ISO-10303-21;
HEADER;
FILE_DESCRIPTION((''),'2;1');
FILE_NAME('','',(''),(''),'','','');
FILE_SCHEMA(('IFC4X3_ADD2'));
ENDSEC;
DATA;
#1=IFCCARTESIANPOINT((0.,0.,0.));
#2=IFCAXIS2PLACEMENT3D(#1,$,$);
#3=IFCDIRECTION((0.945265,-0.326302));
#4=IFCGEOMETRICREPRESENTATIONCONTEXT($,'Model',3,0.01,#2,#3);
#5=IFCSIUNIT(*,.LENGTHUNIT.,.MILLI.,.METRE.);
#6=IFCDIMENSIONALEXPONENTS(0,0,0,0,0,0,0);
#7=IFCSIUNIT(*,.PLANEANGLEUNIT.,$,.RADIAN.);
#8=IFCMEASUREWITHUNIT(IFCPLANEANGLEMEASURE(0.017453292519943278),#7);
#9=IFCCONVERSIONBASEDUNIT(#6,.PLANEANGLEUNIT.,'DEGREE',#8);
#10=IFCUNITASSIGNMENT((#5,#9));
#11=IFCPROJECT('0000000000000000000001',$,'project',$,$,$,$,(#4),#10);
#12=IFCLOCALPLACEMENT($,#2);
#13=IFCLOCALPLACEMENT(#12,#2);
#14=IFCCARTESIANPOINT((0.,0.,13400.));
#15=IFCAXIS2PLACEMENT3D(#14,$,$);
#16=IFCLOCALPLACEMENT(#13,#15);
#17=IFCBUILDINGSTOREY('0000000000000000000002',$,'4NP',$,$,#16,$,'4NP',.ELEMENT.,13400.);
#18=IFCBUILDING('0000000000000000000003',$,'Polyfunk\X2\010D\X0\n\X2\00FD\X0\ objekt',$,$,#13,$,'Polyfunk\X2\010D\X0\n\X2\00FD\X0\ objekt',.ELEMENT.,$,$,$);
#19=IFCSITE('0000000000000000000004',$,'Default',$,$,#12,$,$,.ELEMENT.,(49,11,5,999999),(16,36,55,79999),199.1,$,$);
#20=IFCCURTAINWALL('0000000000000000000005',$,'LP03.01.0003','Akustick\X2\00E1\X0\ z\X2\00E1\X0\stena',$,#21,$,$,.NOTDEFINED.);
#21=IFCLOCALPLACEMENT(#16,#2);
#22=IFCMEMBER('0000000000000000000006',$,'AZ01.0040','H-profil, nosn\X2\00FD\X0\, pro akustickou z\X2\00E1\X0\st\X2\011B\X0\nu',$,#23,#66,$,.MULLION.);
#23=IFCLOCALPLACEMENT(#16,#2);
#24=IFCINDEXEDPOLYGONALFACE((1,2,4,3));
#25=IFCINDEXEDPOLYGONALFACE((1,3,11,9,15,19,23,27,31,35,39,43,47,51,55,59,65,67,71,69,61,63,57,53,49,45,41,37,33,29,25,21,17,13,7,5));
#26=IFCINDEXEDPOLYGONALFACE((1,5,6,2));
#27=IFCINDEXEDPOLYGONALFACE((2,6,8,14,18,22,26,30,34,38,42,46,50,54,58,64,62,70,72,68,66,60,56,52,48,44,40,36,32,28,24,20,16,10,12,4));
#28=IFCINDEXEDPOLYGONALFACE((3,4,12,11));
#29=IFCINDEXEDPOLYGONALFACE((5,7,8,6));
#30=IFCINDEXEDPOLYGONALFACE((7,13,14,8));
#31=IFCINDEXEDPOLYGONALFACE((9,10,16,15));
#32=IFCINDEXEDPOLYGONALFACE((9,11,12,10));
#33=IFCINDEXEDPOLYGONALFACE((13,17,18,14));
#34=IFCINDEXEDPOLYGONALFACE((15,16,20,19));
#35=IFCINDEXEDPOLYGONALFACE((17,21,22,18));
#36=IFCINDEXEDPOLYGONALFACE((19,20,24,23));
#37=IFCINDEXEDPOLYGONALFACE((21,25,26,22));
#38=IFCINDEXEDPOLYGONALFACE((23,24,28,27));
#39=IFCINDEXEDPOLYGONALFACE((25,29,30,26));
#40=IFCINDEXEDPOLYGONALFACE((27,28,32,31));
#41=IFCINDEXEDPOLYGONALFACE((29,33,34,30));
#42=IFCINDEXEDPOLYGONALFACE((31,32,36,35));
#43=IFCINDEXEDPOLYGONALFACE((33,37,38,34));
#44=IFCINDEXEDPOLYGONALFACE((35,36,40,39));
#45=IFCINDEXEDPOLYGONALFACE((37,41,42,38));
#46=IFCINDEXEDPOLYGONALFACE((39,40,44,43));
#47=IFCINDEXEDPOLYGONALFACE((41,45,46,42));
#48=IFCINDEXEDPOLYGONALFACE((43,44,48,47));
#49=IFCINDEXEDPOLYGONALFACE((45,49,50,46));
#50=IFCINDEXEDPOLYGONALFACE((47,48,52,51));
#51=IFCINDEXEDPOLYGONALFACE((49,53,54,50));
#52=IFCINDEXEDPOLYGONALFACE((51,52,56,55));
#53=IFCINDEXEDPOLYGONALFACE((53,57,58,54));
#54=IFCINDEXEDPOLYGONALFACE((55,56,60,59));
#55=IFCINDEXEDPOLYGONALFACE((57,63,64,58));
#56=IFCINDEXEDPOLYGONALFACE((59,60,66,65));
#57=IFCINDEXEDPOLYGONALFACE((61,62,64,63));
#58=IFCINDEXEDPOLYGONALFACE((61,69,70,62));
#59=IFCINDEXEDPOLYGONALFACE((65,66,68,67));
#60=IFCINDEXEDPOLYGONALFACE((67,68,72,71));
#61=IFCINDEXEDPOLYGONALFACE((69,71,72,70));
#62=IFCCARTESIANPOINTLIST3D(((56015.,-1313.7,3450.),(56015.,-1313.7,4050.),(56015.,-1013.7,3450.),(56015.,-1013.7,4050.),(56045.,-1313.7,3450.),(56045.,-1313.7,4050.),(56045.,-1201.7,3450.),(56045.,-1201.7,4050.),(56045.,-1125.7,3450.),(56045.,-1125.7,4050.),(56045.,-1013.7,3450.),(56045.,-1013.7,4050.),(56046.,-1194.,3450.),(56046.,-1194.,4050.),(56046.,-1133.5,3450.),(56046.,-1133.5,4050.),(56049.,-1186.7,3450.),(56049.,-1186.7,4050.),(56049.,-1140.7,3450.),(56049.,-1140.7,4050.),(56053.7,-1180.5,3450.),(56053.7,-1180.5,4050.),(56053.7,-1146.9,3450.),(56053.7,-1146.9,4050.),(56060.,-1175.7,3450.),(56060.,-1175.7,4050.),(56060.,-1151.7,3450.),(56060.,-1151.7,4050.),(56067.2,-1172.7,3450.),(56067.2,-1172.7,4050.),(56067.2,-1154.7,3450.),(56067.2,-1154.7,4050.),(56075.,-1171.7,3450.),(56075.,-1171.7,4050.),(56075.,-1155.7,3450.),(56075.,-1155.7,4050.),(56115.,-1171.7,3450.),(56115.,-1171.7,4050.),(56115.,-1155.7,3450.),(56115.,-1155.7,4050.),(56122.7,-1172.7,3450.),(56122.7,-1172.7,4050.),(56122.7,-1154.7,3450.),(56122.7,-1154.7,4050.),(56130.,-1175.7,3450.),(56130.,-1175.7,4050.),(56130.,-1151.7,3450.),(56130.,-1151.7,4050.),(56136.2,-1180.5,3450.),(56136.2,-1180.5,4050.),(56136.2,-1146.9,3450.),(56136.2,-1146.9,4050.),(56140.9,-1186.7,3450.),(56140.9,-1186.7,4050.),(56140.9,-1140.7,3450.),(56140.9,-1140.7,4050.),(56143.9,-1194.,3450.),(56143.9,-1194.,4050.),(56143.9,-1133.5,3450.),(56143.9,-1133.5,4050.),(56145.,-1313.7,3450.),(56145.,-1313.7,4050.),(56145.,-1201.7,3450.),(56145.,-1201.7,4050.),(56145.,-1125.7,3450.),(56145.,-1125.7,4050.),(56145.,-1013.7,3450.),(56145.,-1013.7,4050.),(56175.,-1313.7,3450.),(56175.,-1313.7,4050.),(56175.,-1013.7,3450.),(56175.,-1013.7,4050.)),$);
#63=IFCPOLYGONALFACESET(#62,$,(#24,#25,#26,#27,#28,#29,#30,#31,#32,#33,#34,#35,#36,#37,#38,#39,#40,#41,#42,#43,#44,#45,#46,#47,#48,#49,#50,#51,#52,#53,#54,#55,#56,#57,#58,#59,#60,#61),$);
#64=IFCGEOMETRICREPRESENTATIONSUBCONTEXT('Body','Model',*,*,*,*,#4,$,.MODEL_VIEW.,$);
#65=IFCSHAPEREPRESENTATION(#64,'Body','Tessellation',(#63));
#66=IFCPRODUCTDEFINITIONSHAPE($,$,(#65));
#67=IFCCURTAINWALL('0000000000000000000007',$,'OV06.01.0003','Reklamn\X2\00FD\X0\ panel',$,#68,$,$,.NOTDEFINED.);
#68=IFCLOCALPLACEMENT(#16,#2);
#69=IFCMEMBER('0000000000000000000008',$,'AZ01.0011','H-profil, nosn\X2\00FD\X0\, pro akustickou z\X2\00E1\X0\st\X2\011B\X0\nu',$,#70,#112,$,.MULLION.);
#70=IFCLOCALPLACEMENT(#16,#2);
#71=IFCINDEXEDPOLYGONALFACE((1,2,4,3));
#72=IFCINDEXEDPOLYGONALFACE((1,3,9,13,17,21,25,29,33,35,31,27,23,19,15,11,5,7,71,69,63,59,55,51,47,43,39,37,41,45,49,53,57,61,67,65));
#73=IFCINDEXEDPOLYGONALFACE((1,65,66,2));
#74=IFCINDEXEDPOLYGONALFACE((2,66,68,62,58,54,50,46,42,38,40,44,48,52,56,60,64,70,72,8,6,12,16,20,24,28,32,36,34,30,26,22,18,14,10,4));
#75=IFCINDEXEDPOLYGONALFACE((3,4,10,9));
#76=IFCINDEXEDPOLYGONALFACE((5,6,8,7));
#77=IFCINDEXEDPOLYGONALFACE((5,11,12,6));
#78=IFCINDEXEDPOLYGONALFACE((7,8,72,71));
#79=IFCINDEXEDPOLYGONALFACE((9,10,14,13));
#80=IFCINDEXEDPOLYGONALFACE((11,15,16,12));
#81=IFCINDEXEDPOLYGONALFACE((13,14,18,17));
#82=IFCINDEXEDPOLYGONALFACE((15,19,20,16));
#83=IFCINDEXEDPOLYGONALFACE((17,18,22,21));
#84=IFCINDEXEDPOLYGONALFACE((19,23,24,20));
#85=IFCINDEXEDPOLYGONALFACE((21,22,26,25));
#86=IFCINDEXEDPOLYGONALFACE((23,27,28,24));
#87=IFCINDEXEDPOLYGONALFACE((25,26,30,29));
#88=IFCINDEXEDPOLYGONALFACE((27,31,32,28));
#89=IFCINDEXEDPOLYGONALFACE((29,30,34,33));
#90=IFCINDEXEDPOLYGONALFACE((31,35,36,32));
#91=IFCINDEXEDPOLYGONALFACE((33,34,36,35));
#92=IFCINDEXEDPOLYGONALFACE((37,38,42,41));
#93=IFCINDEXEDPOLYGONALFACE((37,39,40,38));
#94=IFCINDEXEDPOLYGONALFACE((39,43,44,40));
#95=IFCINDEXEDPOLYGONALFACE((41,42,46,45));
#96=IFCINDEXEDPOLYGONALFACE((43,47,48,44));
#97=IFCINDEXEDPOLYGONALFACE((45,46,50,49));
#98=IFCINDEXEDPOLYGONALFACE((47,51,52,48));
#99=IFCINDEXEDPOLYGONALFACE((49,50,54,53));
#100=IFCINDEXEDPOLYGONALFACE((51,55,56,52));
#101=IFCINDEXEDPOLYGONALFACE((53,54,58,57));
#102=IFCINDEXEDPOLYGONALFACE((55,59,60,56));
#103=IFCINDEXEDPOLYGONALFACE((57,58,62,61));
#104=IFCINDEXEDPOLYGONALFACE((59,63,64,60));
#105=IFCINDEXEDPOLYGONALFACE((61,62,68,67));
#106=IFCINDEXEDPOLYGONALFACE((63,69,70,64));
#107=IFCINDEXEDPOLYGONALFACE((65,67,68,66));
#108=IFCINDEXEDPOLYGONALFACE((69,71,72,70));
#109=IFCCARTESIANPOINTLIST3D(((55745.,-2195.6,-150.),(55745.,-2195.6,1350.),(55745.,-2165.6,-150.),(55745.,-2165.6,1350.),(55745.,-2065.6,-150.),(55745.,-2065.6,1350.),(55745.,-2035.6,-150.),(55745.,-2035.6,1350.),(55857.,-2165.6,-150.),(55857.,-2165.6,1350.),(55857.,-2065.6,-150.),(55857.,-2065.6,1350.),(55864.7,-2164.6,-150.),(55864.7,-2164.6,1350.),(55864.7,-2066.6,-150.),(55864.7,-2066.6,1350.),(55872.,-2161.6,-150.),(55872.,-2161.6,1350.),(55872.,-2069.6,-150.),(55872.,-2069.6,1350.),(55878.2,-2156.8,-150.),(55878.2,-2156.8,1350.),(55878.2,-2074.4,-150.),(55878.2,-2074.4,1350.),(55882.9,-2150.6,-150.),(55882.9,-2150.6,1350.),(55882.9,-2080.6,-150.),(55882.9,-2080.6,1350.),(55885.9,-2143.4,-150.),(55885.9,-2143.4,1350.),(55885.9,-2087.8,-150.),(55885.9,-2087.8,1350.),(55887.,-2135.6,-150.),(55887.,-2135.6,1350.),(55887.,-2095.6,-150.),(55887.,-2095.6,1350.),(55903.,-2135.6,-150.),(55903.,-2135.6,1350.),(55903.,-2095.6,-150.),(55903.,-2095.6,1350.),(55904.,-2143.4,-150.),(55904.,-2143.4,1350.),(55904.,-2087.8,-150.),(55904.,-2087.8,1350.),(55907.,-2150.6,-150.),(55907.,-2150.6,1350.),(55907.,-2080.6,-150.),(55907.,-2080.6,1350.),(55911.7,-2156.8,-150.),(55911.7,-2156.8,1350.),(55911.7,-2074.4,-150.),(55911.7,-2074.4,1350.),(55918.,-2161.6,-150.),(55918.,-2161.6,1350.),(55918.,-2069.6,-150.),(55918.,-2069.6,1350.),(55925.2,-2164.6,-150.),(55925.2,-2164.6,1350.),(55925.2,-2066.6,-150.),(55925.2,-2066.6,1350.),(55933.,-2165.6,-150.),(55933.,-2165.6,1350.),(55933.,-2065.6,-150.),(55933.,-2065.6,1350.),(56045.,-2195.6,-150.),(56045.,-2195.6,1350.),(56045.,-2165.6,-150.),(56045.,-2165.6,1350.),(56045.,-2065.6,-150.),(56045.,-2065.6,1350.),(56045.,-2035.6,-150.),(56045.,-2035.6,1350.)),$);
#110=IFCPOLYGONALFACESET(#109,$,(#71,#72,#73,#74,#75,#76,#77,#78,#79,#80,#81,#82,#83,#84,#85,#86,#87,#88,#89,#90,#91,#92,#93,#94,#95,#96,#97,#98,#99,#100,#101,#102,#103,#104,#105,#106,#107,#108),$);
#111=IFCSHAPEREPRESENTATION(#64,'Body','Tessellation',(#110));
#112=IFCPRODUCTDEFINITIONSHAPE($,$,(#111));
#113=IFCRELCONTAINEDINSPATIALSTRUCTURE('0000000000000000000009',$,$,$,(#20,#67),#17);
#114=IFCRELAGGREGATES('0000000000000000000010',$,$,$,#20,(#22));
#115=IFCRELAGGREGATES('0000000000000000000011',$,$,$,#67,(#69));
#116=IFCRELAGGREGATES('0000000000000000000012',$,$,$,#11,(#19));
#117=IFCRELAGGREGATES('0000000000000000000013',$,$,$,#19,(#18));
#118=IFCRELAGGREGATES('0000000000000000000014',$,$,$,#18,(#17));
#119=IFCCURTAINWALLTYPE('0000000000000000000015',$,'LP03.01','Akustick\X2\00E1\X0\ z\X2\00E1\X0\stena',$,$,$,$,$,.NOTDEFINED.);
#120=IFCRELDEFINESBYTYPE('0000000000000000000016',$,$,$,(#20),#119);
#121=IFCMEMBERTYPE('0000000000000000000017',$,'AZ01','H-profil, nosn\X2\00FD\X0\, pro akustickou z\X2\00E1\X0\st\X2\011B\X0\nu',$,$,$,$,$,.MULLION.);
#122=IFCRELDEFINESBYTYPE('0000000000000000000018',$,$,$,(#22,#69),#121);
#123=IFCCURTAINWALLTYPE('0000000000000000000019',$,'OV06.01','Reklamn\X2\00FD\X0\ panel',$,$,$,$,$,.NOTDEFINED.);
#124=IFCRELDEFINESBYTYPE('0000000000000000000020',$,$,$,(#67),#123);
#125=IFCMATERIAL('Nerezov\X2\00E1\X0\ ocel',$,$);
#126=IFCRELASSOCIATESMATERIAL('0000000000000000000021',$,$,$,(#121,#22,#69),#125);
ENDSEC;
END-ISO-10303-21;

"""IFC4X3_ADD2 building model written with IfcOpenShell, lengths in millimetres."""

from ifc_helpers import new_model, entity, si_unit, converted_unit, direction, frame, frame_2d, origin, place, context, subcontext, project, spatial, polyline, circle_curve, parameter, trimmed, segment, composite_curve, outline, extrude, source, transform, mapped, material, material_profile, profile_set, profile_usage, type_object, element, aggregate, save


model = new_model("IFC4X3_ADD2")

# Units and contexts
model_context = context("Model", 3, precision=0.01, world=origin(), true_north=direction((0.945265, -0.326302)))
body_context = subcontext(model_context, "Body", "Model", "MODEL_VIEW")
ifc_project = project(units=[si_unit("LENGTHUNIT", "METRE", prefix="MILLI"), converted_unit("PLANEANGLEUNIT", "DEGREE", entity("IfcPlaneAngleMeasure", 0.017453292519943278), si_unit("PLANEANGLEUNIT", "RADIAN"), dimensions=[0, 0, 0, 0, 0, 0, 0])], contexts=[model_context])

# Site, building, storey
site_placement = place(None, origin())
site = spatial("IfcSite", under=ifc_project, at=site_placement, Name="Default", CompositionType="ELEMENT", RefLatitude=(49, 11, 5, 999999), RefLongitude=(16, 36, 55, 79999), RefElevation=199.1)
building_placement = place(site_placement, origin())
building = spatial("IfcBuilding", under=site, at=building_placement, Name="Polyfunkčný objekt", LongName="Polyfunkčný objekt", CompositionType="ELEMENT")
storey_placement = place(building_placement, frame((0.0, 0.0, 13400.0)))
storey = spatial("IfcBuildingStorey", under=building, at=storey_placement, Name="4NP", LongName="4NP", CompositionType="ELEMENT", Elevation=13400.0)

# Shared definitions
curtain_wall_type_1 = type_object("IfcCurtainWallType", Name="LP03.01", Description="Akustická zástena", PredefinedType="NOTDEFINED")
ifc_material_1 = material(Name="Nerezová ocel")
ifc_material_profile = material_profile(ifc_material_1, outline(composite_curve([segment(polyline([(50.0, -150.0), (80.0, -150.0)]), True, "CONTINUOUS"), segment(polyline([(80.0, -150.0), (80.0, 150.0)]), True, "CONTINUOUS"), segment(polyline([(80.0, 150.0), (50.0, 150.0)]), True, "CONTINUOUS"), segment(polyline([(50.0, 150.0), (50.0, 38.0)]), True, "CONTINUOUS"), segment(trimmed(circle_curve(frame_2d((20.0, 38.0), x_axis=(0.0, 1.0)), 30.0), [parameter(180.0)], [parameter(270.0)], True, "PARAMETER"), False, "CONTINUOUS"), segment(polyline([(20.0, 8.0), (-20.0, 8.0)]), True, "CONTINUOUS"), segment(trimmed(circle_curve(frame_2d((-20.0, 38.0), x_axis=(0.0, 1.0)), 30.0), [parameter(90.0)], [parameter(180.0)], True, "PARAMETER"), False, "CONTINUOUS"), segment(polyline([(-50.0, 38.0), (-50.0, 150.0)]), True, "CONTINUOUS"), segment(polyline([(-50.0, 150.0), (-80.0, 150.0)]), True, "CONTINUOUS"), segment(polyline([(-80.0, 150.0), (-80.0, -150.0)]), True, "CONTINUOUS"), segment(polyline([(-80.0, -150.0), (-50.0, -150.0)]), True, "CONTINUOUS"), segment(polyline([(-50.0, -150.0), (-50.0, -38.0)]), True, "CONTINUOUS"), segment(trimmed(circle_curve(frame_2d((-20.0, -38.0), x_axis=(0.0, 1.0)), 30.0), [parameter(0.0)], [parameter(90.0)], True, "PARAMETER"), False, "CONTINUOUS"), segment(polyline([(-20.0, -8.0), (20.0, -8.0)]), True, "CONTINUOUS"), segment(trimmed(circle_curve(frame_2d((20.0, -38.0), x_axis=(0.0, 1.0)), 30.0), [parameter(270.0)], [parameter(0.0)], True, "PARAMETER"), False, "CONTINUOUS"), segment(polyline([(50.0, -38.0), (50.0, -150.0)]), True, "CONTINUOUS")], self_intersect=False)), Name="Profil zástena")
ifc_profile_set = profile_set([ifc_material_profile], Name="Profil zástena")
ifc_profile_usage = profile_usage(ifc_profile_set)
member_type = type_object("IfcMemberType", Name="AZ01", Description="H-profil, nosný, pro akustickou zástěnu", PredefinedType="MULLION", material=ifc_profile_set)

# Curtain wall, member
curtain_wall_1_placement = place(storey_placement, frame((0.0, 0.0, -13400.0)))
curtain_wall_1 = element("IfcCurtainWall", 1, at=curtain_wall_1_placement, inside=storey, type_object=curtain_wall_type_1, Name="LP03.01.0003", Description="Akustická zástena", PredefinedType="NOTDEFINED")
shared_shape_1 = source(origin(), body_context, "Body", "SweptSolid", [
    extrude(outline(composite_curve([segment(polyline([(50.0, -150.0), (80.0, -150.0)]), True, "CONTINUOUS"), segment(polyline([(80.0, -150.0), (80.0, 150.0)]), True, "CONTINUOUS"), segment(polyline([(80.0, 150.0), (50.0, 150.0)]), True, "CONTINUOUS"), segment(polyline([(50.0, 150.0), (50.0, 38.0)]), True, "CONTINUOUS"), segment(trimmed(circle_curve(frame_2d((20.0, 38.0), x_axis=(0.0, 1.0)), 30.0), [parameter(180.0)], [parameter(270.0)], True, "PARAMETER"), False, "CONTINUOUS"), segment(polyline([(20.0, 8.0), (-20.0, 8.0)]), True, "CONTINUOUS"), segment(trimmed(circle_curve(frame_2d((-20.0, 38.0), x_axis=(0.0, 1.0)), 30.0), [parameter(90.0)], [parameter(180.0)], True, "PARAMETER"), False, "CONTINUOUS"), segment(polyline([(-50.0, 38.0), (-50.0, 150.0)]), True, "CONTINUOUS"), segment(polyline([(-50.0, 150.0), (-80.0, 150.0)]), True, "CONTINUOUS"), segment(polyline([(-80.0, 150.0), (-80.0, -150.0)]), True, "CONTINUOUS"), segment(polyline([(-80.0, -150.0), (-50.0, -150.0)]), True, "CONTINUOUS"), segment(polyline([(-50.0, -150.0), (-50.0, -38.0)]), True, "CONTINUOUS"), segment(trimmed(circle_curve(frame_2d((-20.0, -38.0), x_axis=(0.0, 1.0)), 30.0), [parameter(0.0)], [parameter(90.0)], True, "PARAMETER"), False, "CONTINUOUS"), segment(polyline([(-20.0, -8.0), (20.0, -8.0)]), True, "CONTINUOUS"), segment(trimmed(circle_curve(frame_2d((20.0, -38.0), x_axis=(0.0, 1.0)), 30.0), [parameter(270.0)], [parameter(0.0)], True, "PARAMETER"), False, "CONTINUOUS"), segment(polyline([(50.0, -38.0), (50.0, -150.0)]), True, "CONTINUOUS")], self_intersect=False)), frame((-150.0, 0.0, -600.0), z_axis=(0.0, 0.0, 1.0), x_axis=(0.0, 1.0, 0.0)), (0.0, 0.0, 1.0), 600.0),
])
member_1_placement = place(curtain_wall_1_placement, frame((56095.0, -1313.7, 17450.0), z_axis=(0.0, 0.0, 1.0), x_axis=(0.0, -1.0, 0.0)))
member_1 = element("IfcMember", 2, at=member_1_placement, type_object=member_type, material=ifc_profile_usage, Name="AZ01.0040", Description="H-profil, nosný, pro akustickou zástěnu", PredefinedType="MULLION", context=body_context, shape_type="MappedRepresentation", body=[
    mapped(shared_shape_1, transform((0.0, 0.0, 0.0), scale=1.0)),
])
aggregate(curtain_wall_1, [member_1])

# Curtain wall, member
curtain_wall_type_2 = type_object("IfcCurtainWallType", Name="OV06.01", Description="Reklamný panel", PredefinedType="NOTDEFINED")
curtain_wall_2_placement = place(storey_placement, frame((0.0, 0.0, -13400.0)))
curtain_wall_2 = element("IfcCurtainWall", 3, at=curtain_wall_2_placement, inside=storey, type_object=curtain_wall_type_2, Name="OV06.01.0003", Description="Reklamný panel", PredefinedType="NOTDEFINED")
shared_shape_2 = source(origin(), body_context, "Body", "SweptSolid", [
    extrude(outline(composite_curve([segment(polyline([(-150.0, -50.0), (-150.0, -80.0)]), True, "CONTINUOUS"), segment(polyline([(-150.0, -80.0), (150.0, -80.0)]), True, "CONTINUOUS"), segment(polyline([(150.0, -80.0), (150.0, -50.0)]), True, "CONTINUOUS"), segment(polyline([(150.0, -50.0), (38.0, -50.0)]), True, "CONTINUOUS"), segment(trimmed(circle_curve(frame_2d((38.0, -20.0), x_axis=(1.0, 0.0)), 30.0), [parameter(180.0)], [parameter(270.0)], True, "PARAMETER"), False, "CONTINUOUS"), segment(polyline([(8.0, -20.0), (8.0, 20.0)]), True, "CONTINUOUS"), segment(trimmed(circle_curve(frame_2d((38.0, 20.0), x_axis=(1.0, 0.0)), 30.0), [parameter(90.0)], [parameter(180.0)], True, "PARAMETER"), False, "CONTINUOUS"), segment(polyline([(38.0, 50.0), (150.0, 50.0)]), True, "CONTINUOUS"), segment(polyline([(150.0, 50.0), (150.0, 80.0)]), True, "CONTINUOUS"), segment(polyline([(150.0, 80.0), (-150.0, 80.0)]), True, "CONTINUOUS"), segment(polyline([(-150.0, 80.0), (-150.0, 50.0)]), True, "CONTINUOUS"), segment(polyline([(-150.0, 50.0), (-38.0, 50.0)]), True, "CONTINUOUS"), segment(trimmed(circle_curve(frame_2d((-38.0, 20.0), x_axis=(1.0, 0.0)), 30.0), [parameter(0.0)], [parameter(90.0)], True, "PARAMETER"), False, "CONTINUOUS"), segment(polyline([(-8.0, 20.0), (-8.0, -20.0)]), True, "CONTINUOUS"), segment(trimmed(circle_curve(frame_2d((-38.0, -20.0), x_axis=(1.0, 0.0)), 30.0), [parameter(270.0)], [parameter(0.0)], True, "PARAMETER"), False, "CONTINUOUS"), segment(polyline([(-38.0, -50.0), (-150.0, -50.0)]), True, "CONTINUOUS")], self_intersect=False)), frame((-150.0, 0.0, -1500.0), z_axis=(0.0, 0.0, -1.0), x_axis=(1.0, 0.0, 0.0)), (0.0, 0.0, -1.0), 1500.0),
])
member_2_placement = place(curtain_wall_2_placement, frame((56045.0, -2115.6, 13250.0), z_axis=(0.0, 0.0, -1.0), x_axis=(1.0, 0.0, 0.0)))
member_2 = element("IfcMember", 4, at=member_2_placement, type_object=member_type, material=ifc_profile_usage, Name="AZ01.0011", Description="H-profil, nosný, pro akustickou zástěnu", PredefinedType="MULLION", context=body_context, shape_type="MappedRepresentation", body=[
    mapped(shared_shape_2, transform((0.0, 0.0, 0.0), scale=1.0)),
])
aggregate(curtain_wall_2, [member_2])

save(model, "model.ifc")
